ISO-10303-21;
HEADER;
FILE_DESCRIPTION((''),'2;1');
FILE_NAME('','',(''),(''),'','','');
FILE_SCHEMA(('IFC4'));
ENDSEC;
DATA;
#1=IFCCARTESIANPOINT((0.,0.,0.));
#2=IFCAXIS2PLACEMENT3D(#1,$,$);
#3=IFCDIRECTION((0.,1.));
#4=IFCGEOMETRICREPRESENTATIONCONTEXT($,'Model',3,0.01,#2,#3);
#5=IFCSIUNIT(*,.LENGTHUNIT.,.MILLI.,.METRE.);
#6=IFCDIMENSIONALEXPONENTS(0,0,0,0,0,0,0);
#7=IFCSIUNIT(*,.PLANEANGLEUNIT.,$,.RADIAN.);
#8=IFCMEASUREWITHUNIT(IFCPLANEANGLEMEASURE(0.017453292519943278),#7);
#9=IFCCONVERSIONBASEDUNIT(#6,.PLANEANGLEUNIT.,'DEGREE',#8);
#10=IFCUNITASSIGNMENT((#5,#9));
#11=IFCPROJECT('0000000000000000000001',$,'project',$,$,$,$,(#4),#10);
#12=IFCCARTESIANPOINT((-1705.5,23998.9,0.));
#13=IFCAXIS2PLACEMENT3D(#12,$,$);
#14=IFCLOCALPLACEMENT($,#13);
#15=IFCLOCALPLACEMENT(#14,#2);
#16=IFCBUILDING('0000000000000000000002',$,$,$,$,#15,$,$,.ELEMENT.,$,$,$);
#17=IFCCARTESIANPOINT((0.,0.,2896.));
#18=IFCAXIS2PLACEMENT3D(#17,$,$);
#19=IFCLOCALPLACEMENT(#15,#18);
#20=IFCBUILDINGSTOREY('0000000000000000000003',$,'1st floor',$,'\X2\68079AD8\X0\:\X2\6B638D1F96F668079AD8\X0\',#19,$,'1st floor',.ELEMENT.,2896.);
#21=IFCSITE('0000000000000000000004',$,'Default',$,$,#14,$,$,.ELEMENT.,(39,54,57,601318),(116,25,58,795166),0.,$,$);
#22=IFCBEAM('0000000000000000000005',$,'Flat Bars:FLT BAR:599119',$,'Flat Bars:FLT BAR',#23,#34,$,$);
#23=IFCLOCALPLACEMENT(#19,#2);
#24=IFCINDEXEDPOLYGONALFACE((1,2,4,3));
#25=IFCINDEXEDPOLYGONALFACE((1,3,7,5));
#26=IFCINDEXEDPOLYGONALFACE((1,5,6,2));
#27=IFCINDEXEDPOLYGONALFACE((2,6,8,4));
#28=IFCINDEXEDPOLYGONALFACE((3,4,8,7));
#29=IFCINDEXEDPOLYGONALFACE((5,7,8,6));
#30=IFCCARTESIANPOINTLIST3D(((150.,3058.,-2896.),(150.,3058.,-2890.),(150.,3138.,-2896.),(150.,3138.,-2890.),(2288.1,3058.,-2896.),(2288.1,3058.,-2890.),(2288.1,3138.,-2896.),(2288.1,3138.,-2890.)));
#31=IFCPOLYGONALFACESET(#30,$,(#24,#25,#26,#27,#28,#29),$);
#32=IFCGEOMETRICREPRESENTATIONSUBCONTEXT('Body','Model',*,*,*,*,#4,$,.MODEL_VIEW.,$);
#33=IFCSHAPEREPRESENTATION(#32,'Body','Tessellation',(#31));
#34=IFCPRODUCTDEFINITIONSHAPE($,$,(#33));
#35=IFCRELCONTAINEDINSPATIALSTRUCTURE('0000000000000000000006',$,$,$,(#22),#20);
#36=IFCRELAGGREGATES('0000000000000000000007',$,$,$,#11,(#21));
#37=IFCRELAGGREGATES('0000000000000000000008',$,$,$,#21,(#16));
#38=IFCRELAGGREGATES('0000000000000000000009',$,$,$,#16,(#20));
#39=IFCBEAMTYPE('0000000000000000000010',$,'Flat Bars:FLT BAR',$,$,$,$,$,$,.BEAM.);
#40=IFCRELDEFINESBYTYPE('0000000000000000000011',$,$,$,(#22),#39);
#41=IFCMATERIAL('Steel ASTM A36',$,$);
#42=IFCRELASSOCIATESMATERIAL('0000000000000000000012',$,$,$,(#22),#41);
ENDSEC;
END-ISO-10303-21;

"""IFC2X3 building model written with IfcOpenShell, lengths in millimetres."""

from ifc_helpers import new_model, entity, si_unit, converted_unit, direction, frame, origin, origin_2d_with_axis, place, context, subcontext, project, spatial, rectangle, extrude, material, type_object, element, save


model = new_model("IFC2X3")

# Units and contexts
model_context = context("Model", 3, precision=0.01, world=origin(), true_north=direction((0.0, 1.0)))
body_context = subcontext(model_context, "Body", "Model", "MODEL_VIEW")
ifc_project = project(units=[si_unit("LENGTHUNIT", "METRE", prefix="MILLI"), converted_unit("PLANEANGLEUNIT", "DEGREE", entity("IfcPlaneAngleMeasure", 0.017453292519943278), si_unit("PLANEANGLEUNIT", "RADIAN"), dimensions=[0, 0, 0, 0, 0, 0, 0])], contexts=[model_context])

# Site, building, storey
site_placement = place(None, frame((-1705.5, 23998.9, 0.0)))
site = spatial("IfcSite", under=ifc_project, at=site_placement, Name="Default", CompositionType="ELEMENT", RefLatitude=(39, 54, 57, 601318), RefLongitude=(116, 25, 58, 795166), RefElevation=0.0)
building_placement = place(site_placement, origin())
building = spatial("IfcBuilding", under=site, at=building_placement, CompositionType="ELEMENT")
storey_placement = place(building_placement, frame((0.0, 0.0, 2896.0)))
storey = spatial("IfcBuildingStorey", under=building, at=storey_placement, Name="1st floor", ObjectType="标高:正负零标高", LongName="1st floor", CompositionType="ELEMENT", Elevation=2896.0)

# Beam
ifc_material_1 = material(Name="Steel ASTM A36")
beam_type_1 = type_object("IfcBeamType", Name="Flat Bars:FLT BAR", PredefinedType="BEAM")
beam_1_placement = place(storey_placement, frame((150.0, 3098.0, -2890.0)))
element("IfcBeam", 1, at=beam_1_placement, inside=storey, type_object=beam_type_1, material=ifc_material_1, Name="Flat Bars:FLT BAR:599119", ObjectType="Flat Bars:FLT BAR", context=body_context, shape_type="SweptSolid", body=[
    extrude(rectangle(XDim=6.0, YDim=80.0, at=origin_2d_with_axis()), frame((0.0, 0.0, -3.0), z_axis=(1.0, 0.0, 0.0), x_axis=(0.0, 0.0, -1.0)), (0.0, 0.0, 1.0), 2138.1),
])

save(model, "model.ifc")
